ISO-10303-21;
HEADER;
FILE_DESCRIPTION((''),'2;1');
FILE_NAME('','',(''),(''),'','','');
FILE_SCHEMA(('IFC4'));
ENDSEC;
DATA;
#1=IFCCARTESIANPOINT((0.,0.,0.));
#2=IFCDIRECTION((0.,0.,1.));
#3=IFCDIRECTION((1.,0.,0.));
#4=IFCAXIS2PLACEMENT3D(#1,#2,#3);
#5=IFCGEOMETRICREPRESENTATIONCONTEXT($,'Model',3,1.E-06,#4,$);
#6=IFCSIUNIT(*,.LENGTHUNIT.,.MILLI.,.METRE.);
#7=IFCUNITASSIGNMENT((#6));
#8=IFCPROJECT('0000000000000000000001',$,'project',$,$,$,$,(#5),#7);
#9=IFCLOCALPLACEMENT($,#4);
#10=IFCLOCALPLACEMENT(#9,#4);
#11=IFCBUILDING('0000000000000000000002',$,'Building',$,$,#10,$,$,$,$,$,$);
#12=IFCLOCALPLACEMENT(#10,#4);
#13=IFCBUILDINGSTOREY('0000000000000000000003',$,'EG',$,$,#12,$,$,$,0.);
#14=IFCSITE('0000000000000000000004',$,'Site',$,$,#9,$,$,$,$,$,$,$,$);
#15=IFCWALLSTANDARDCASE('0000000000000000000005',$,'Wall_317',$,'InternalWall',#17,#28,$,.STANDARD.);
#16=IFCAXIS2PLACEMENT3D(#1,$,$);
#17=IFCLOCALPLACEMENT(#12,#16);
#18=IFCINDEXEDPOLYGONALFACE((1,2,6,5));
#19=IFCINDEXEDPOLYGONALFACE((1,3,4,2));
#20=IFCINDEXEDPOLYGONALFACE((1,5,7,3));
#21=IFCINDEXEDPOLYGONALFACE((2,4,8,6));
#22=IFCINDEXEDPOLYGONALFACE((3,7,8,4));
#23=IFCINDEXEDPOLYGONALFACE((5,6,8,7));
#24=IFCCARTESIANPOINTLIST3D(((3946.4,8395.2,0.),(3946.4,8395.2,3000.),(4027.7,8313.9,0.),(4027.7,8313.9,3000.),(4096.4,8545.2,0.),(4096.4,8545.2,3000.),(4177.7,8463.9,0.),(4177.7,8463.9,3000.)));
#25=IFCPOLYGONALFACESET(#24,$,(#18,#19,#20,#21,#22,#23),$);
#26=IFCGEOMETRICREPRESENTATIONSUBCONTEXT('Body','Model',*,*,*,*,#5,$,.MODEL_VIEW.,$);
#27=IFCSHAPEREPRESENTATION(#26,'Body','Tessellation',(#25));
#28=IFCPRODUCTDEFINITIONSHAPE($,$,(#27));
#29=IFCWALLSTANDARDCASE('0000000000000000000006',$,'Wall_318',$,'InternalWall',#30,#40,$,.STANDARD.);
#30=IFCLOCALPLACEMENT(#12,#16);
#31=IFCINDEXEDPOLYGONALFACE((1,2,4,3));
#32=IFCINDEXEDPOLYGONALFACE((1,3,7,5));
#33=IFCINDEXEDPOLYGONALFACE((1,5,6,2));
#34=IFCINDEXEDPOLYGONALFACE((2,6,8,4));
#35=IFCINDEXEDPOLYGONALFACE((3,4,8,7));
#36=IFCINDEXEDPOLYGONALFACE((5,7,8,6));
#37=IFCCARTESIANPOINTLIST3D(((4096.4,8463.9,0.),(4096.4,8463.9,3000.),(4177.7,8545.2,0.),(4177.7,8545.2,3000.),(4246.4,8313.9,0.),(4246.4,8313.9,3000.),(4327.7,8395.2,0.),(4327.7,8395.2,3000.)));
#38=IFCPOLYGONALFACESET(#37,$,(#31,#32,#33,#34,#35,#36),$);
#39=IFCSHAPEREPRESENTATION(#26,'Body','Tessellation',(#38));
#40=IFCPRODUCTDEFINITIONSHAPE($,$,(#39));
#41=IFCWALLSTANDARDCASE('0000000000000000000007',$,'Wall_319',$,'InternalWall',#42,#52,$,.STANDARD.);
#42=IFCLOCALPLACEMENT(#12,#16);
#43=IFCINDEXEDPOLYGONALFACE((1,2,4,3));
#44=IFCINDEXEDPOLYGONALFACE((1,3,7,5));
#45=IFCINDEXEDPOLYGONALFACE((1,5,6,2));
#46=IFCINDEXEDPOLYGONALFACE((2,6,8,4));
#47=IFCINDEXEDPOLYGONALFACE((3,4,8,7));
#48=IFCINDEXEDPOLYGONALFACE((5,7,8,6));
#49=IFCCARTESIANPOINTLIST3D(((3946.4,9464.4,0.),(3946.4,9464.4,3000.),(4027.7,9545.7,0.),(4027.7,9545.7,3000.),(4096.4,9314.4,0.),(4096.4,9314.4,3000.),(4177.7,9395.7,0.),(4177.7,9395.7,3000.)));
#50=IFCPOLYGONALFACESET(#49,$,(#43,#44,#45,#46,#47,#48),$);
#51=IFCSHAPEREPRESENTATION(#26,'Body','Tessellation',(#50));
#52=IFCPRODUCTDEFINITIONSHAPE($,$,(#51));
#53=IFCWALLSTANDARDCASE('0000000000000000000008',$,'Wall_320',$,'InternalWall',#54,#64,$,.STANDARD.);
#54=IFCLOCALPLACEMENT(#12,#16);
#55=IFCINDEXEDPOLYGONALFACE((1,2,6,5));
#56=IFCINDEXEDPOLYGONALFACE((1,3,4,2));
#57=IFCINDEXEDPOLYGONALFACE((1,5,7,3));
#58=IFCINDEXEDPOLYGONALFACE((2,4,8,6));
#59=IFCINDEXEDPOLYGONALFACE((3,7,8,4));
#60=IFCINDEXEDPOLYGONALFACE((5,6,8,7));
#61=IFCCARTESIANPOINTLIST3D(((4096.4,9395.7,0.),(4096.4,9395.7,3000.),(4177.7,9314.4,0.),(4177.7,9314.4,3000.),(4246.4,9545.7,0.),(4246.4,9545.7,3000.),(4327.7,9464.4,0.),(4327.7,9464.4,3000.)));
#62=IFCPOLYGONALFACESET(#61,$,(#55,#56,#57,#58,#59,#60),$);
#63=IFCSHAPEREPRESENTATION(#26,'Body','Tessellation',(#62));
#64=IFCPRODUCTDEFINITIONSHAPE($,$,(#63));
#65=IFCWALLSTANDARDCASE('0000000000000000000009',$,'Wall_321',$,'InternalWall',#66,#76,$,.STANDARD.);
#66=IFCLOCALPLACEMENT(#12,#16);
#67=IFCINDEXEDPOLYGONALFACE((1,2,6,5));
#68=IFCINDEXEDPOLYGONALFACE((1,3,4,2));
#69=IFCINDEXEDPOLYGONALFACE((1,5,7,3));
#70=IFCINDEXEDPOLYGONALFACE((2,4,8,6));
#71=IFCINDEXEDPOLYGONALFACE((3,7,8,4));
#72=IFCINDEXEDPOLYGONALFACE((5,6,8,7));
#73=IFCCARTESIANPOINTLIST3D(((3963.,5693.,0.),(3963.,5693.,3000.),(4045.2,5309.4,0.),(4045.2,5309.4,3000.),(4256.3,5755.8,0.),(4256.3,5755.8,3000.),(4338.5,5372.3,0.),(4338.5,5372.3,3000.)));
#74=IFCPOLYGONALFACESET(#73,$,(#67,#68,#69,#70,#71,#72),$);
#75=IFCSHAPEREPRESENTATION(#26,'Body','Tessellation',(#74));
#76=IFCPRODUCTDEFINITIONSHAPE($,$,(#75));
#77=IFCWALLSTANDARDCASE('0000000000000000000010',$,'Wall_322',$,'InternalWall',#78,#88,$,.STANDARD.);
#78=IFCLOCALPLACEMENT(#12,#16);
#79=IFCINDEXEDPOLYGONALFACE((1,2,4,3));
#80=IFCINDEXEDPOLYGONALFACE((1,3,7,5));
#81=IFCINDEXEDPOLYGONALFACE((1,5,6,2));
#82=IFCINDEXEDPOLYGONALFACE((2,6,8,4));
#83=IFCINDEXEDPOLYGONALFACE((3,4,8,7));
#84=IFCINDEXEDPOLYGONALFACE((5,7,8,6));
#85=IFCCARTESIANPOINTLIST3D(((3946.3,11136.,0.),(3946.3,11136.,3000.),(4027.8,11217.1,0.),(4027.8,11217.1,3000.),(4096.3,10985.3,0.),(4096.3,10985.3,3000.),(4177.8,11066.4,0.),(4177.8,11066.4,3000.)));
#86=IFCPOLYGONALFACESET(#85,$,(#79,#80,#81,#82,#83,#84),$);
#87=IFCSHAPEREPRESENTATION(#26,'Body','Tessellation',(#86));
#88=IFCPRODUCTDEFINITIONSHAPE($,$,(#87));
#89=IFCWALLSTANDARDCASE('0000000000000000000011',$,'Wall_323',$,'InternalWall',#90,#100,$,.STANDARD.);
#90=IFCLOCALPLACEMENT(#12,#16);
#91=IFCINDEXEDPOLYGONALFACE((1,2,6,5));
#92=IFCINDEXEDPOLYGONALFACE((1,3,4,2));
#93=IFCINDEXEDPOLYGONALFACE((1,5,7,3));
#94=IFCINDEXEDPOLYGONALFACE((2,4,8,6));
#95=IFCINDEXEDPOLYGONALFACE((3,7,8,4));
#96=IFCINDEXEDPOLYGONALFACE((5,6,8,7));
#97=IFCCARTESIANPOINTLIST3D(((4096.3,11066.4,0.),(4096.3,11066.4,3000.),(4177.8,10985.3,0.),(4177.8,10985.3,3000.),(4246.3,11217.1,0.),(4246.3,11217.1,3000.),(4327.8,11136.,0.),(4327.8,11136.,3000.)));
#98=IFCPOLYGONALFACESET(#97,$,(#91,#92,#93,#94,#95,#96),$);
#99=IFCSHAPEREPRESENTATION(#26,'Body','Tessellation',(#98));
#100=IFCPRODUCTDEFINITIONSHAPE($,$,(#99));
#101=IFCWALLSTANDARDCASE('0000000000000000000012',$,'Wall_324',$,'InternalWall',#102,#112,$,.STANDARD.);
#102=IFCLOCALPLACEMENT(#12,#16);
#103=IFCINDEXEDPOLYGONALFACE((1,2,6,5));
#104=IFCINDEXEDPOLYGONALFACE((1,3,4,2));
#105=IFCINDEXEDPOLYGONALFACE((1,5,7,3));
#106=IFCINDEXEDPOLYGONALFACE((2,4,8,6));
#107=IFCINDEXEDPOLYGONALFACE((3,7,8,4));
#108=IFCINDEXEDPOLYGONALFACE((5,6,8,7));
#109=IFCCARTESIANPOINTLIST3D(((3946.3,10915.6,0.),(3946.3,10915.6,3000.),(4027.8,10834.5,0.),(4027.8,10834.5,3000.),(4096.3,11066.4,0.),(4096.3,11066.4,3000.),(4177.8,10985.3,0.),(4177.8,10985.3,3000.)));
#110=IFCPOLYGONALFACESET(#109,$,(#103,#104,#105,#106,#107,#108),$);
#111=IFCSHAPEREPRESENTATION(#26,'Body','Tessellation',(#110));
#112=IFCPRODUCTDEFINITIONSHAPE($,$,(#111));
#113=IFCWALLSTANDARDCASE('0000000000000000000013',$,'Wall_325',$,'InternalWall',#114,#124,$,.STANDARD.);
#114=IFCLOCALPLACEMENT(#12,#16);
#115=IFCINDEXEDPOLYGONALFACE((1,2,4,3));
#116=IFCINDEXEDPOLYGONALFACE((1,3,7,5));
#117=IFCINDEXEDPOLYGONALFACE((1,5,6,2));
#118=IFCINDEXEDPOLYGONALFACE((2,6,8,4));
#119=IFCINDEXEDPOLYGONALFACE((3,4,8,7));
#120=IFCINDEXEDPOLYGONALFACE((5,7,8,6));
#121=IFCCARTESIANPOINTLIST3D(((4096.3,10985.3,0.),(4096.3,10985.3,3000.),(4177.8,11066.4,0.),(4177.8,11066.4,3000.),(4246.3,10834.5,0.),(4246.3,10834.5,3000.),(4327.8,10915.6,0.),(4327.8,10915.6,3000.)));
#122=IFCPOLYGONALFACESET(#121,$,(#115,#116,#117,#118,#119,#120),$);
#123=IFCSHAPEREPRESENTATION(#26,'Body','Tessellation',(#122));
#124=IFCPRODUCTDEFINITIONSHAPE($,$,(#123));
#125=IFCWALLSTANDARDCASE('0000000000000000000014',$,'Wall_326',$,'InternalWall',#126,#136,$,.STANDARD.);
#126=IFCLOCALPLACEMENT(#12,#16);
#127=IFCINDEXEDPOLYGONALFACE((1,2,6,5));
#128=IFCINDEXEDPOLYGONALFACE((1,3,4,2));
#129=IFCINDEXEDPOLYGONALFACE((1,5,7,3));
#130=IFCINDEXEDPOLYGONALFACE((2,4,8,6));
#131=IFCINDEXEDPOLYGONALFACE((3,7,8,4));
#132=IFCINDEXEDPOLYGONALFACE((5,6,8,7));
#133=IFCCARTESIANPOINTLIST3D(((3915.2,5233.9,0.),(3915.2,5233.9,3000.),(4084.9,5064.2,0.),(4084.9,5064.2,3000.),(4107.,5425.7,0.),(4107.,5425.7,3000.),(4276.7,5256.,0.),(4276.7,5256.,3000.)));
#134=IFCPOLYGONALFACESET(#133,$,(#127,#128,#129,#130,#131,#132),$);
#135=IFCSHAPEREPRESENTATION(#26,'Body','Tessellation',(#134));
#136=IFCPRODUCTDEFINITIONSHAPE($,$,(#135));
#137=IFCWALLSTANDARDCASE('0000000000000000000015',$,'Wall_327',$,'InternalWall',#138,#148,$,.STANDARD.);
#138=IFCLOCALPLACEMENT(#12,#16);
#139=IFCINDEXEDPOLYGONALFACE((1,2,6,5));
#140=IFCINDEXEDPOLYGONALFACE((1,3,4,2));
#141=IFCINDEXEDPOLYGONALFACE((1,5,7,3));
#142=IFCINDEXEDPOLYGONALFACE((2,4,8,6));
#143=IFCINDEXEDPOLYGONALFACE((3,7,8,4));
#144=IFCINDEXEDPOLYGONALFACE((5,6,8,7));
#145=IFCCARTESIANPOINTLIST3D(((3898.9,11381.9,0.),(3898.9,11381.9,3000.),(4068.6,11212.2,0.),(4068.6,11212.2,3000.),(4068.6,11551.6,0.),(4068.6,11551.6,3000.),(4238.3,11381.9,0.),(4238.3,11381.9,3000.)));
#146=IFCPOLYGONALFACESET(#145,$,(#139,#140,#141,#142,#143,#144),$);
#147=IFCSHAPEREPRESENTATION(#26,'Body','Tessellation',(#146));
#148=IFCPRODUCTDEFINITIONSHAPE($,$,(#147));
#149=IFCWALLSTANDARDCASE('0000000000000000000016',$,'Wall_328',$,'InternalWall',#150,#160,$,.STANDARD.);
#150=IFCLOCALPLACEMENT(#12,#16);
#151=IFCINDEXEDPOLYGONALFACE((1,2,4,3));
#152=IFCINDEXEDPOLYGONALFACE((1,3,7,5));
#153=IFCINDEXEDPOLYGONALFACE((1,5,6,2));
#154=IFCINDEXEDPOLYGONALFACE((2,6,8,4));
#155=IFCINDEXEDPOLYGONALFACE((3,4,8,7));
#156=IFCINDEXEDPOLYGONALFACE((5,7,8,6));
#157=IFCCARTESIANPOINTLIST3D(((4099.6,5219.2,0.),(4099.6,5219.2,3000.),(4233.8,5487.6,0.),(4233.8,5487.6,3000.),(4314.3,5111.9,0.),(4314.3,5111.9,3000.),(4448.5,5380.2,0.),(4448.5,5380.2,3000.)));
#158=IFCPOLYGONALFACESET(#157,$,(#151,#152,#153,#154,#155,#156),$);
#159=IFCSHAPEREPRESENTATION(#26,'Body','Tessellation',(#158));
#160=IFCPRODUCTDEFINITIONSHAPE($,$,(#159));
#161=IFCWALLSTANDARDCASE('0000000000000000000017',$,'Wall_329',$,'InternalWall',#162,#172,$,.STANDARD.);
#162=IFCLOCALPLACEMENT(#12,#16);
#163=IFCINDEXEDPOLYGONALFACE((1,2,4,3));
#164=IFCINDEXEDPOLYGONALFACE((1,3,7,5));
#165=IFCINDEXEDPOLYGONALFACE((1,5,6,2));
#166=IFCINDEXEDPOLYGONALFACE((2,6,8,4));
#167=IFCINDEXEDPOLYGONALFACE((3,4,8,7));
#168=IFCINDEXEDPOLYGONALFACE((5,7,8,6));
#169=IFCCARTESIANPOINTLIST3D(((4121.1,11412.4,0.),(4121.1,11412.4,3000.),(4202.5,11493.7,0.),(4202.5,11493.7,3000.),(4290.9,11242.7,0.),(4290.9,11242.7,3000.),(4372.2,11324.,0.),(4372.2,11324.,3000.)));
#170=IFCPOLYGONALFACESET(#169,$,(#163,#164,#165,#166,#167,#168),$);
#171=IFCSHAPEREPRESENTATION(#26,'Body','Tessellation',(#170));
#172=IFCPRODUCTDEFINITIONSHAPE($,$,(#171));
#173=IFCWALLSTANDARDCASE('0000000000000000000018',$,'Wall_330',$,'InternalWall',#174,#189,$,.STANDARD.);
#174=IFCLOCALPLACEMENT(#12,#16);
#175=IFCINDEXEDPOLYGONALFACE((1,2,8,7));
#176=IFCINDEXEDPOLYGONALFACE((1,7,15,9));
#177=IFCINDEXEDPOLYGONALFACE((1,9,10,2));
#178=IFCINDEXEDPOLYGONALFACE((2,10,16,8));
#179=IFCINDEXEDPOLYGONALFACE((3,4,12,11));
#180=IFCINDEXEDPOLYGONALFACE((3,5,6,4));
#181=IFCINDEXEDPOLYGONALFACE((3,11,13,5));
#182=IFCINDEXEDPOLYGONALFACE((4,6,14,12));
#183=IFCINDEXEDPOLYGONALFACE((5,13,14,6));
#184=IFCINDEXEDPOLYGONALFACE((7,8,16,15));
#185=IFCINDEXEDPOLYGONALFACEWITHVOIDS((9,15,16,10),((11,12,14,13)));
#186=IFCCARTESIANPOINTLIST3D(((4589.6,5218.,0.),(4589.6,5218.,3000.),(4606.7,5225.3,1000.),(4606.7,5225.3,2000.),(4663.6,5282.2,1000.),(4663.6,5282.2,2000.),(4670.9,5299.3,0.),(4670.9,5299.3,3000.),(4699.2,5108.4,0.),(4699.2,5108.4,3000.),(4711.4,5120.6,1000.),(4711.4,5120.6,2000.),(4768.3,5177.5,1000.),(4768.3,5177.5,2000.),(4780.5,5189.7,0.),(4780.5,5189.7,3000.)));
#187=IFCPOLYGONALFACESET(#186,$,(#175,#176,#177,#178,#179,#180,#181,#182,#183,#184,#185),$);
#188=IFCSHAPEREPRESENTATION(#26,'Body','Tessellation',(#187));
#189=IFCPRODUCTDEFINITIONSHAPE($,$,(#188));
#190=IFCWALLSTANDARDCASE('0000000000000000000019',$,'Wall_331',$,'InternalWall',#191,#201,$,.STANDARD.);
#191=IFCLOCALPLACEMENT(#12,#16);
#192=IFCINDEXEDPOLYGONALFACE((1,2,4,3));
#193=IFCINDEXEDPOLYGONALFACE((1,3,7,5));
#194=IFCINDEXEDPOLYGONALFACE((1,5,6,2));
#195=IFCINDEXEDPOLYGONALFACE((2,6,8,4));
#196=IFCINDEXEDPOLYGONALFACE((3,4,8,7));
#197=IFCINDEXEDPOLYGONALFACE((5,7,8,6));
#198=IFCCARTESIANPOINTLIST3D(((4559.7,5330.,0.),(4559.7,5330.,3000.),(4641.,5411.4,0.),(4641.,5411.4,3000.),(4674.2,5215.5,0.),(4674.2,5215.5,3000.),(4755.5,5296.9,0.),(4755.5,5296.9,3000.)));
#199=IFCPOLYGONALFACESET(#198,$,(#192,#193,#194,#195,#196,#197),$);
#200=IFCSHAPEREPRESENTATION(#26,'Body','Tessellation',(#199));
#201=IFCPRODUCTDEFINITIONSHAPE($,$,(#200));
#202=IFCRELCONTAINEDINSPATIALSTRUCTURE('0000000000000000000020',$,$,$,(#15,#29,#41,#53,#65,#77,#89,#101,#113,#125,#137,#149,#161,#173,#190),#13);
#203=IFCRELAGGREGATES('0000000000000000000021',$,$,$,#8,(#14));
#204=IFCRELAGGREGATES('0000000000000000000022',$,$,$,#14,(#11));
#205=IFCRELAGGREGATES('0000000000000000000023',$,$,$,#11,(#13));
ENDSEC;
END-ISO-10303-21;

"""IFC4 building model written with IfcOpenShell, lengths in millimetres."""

from ifc_helpers import new_model, si_unit, frame, origin_with_axes, place, context, subcontext, project, spatial, rectangle, extrude, element, save


model = new_model("IFC4")

# Units and contexts
model_context = context("Model", 3, precision=1e-06, world=origin_with_axes())
body_context = subcontext(model_context, "Body", "Model", "MODEL_VIEW")
ifc_project = project(units=[si_unit("LENGTHUNIT", "METRE", prefix="MILLI")], contexts=[model_context])

# Site, building, storey
site_placement = place(None, origin_with_axes())
site = spatial("IfcSite", under=ifc_project, at=site_placement, Name="Site")
building_placement = place(site_placement, origin_with_axes())
building = spatial("IfcBuilding", under=site, at=building_placement, Name="Building")
storey_placement = place(building_placement, origin_with_axes())
storey = spatial("IfcBuildingStorey", under=building, at=storey_placement, Name="EG", Elevation=0.0)

# Walls
wall_1_placement = place(storey_placement, origin_with_axes())
element("IfcWallStandardCase", 1, at=wall_1_placement, inside=storey, Name="Wall_317", ObjectType="InternalWall", PredefinedType="STANDARD", context=body_context, shape_type="SweptSolid", body=[
    extrude(rectangle(XDim=212.1, YDim=115.0), frame((4062.1, 8429.5, 0.0), z_axis=(0.0, 0.0, 1.0), x_axis=(-0.707107, -0.707107, 0.0)), (0.0, 0.0, 1.0), 3000.0),
])
wall_2_placement = place(storey_placement, origin_with_axes())
element("IfcWallStandardCase", 2, at=wall_2_placement, inside=storey, Name="Wall_318", ObjectType="InternalWall", PredefinedType="STANDARD", context=body_context, shape_type="SweptSolid", body=[
    extrude(rectangle(XDim=212.1, YDim=115.0), frame((4212.1, 8429.5, 0.0), z_axis=(0.0, 0.0, 1.0), x_axis=(0.707107, -0.707107, 0.0)), (0.0, 0.0, 1.0), 3000.0),
])
wall_3_placement = place(storey_placement, origin_with_axes())
element("IfcWallStandardCase", 3, at=wall_3_placement, inside=storey, Name="Wall_319", ObjectType="InternalWall", PredefinedType="STANDARD", context=body_context, shape_type="SweptSolid", body=[
    extrude(rectangle(XDim=212.1, YDim=115.0), frame((4062.1, 9430.0, 0.0), z_axis=(0.0, 0.0, 1.0), x_axis=(-0.707107, 0.707107, 0.0)), (0.0, 0.0, 1.0), 3000.0),
])
wall_4_placement = place(storey_placement, origin_with_axes())
element("IfcWallStandardCase", 4, at=wall_4_placement, inside=storey, Name="Wall_320", ObjectType="InternalWall", PredefinedType="STANDARD", context=body_context, shape_type="SweptSolid", body=[
    extrude(rectangle(XDim=212.1, YDim=115.0), frame((4212.1, 9430.0, 0.0), z_axis=(0.0, 0.0, 1.0), x_axis=(0.707107, 0.707107, 0.0)), (0.0, 0.0, 1.0), 3000.0),
])
wall_5_placement = place(storey_placement, origin_with_axes())
element("IfcWallStandardCase", 5, at=wall_5_placement, inside=storey, Name="Wall_321", ObjectType="InternalWall", PredefinedType="STANDARD", context=body_context, shape_type="SweptSolid", body=[
    extrude(rectangle(XDim=392.3, YDim=300.0), frame((4150.8, 5532.6, 0.0), z_axis=(0.0, 0.0, 1.0), x_axis=(-0.209529, 0.977802, 0.0)), (0.0, 0.0, 1.0), 3000.0),
])
wall_6_placement = place(storey_placement, origin_with_axes())
element("IfcWallStandardCase", 6, at=wall_6_placement, inside=storey, Name="Wall_322", ObjectType="InternalWall", PredefinedType="STANDARD", context=body_context, shape_type="SweptSolid", body=[
    extrude(rectangle(XDim=212.7, YDim=115.0), frame((4062.1, 11101.2, 0.0), z_axis=(0.0, 0.0, 1.0), x_axis=(0.705341, -0.708868, 0.0)), (0.0, 0.0, 1.0), 3000.0),
])
wall_7_placement = place(storey_placement, origin_with_axes())
element("IfcWallStandardCase", 7, at=wall_7_placement, inside=storey, Name="Wall_323", ObjectType="InternalWall", PredefinedType="STANDARD", context=body_context, shape_type="SweptSolid", body=[
    extrude(rectangle(XDim=212.7, YDim=115.0), frame((4212.1, 11101.2, 0.0), z_axis=(0.0, 0.0, 1.0), x_axis=(0.705341, 0.708868, 0.0)), (0.0, 0.0, 1.0), 3000.0),
])
wall_8_placement = place(storey_placement, origin_with_axes())
element("IfcWallStandardCase", 8, at=wall_8_placement, inside=storey, Name="Wall_324", ObjectType="InternalWall", PredefinedType="STANDARD", context=body_context, shape_type="SweptSolid", body=[
    extrude(rectangle(XDim=212.7, YDim=115.0), frame((4062.1, 10950.5, 0.0), z_axis=(0.0, 0.0, 1.0), x_axis=(-0.705341, -0.708868, 0.0)), (0.0, 0.0, 1.0), 3000.0),
])
wall_9_placement = place(storey_placement, origin_with_axes())
element("IfcWallStandardCase", 9, at=wall_9_placement, inside=storey, Name="Wall_325", ObjectType="InternalWall", PredefinedType="STANDARD", context=body_context, shape_type="SweptSolid", body=[
    extrude(rectangle(XDim=212.7, YDim=115.0), frame((4212.1, 10950.5, 0.0), z_axis=(0.0, 0.0, 1.0), x_axis=(0.705341, -0.708868, 0.0)), (0.0, 0.0, 1.0), 3000.0),
])
wall_10_placement = place(storey_placement, origin_with_axes())
element("IfcWallStandardCase", 10, at=wall_10_placement, inside=storey, Name="Wall_326", ObjectType="InternalWall", PredefinedType="STANDARD", context=body_context, shape_type="SweptSolid", body=[
    extrude(rectangle(XDim=271.2, YDim=240.0), frame((4096.0, 5244.9, 0.0), z_axis=(0.0, 0.0, 1.0), x_axis=(-0.707107, -0.707107, 0.0)), (0.0, 0.0, 1.0), 3000.0),
])
wall_11_placement = place(storey_placement, origin_with_axes())
element("IfcWallStandardCase", 11, at=wall_11_placement, inside=storey, Name="Wall_327", ObjectType="InternalWall", PredefinedType="STANDARD", context=body_context, shape_type="SweptSolid", body=[
    extrude(rectangle(XDim=240.0, YDim=240.0), frame((4068.6, 11381.9, 0.0), z_axis=(0.0, 0.0, 1.0), x_axis=(0.707107, 0.707107, 0.0)), (0.0, 0.0, 1.0), 3000.0),
])
wall_12_placement = place(storey_placement, origin_with_axes())
element("IfcWallStandardCase", 12, at=wall_12_placement, inside=storey, Name="Wall_328", ObjectType="InternalWall", PredefinedType="STANDARD", context=body_context, shape_type="SweptSolid", body=[
    extrude(rectangle(XDim=300.0, YDim=240.0), frame((4274.1, 5299.7, 0.0), z_axis=(0.0, 0.0, 1.0), x_axis=(0.447214, 0.894427, 0.0)), (0.0, 0.0, 1.0), 3000.0),
])
wall_13_placement = place(storey_placement, origin_with_axes())
element("IfcWallStandardCase", 13, at=wall_13_placement, inside=storey, Name="Wall_329", ObjectType="InternalWall", PredefinedType="STANDARD", context=body_context, shape_type="SweptSolid", body=[
    extrude(rectangle(XDim=240.0, YDim=115.0), frame((4246.7, 11368.2, 0.0), z_axis=(0.0, 0.0, 1.0), x_axis=(0.707107, -0.707107, 0.0)), (0.0, 0.0, 1.0), 3000.0),
])

# Wall, opening
wall_14_placement = place(storey_placement, origin_with_axes())
wall_14 = element("IfcWallStandardCase", 14, at=wall_14_placement, inside=storey, Name="Wall_330", ObjectType="InternalWall", PredefinedType="STANDARD", context=body_context, shape_type="SweptSolid", body=[
    extrude(rectangle(XDim=155.0, YDim=115.0), frame((4685.0, 5203.9, 0.0), z_axis=(0.0, 0.0, 1.0), x_axis=(-0.707107, 0.707107, 0.0)), (0.0, 0.0, 1.0), 3000.0),
])
opening_placement = place(wall_14_placement, origin_with_axes())
element("IfcOpeningElement", 15, at=opening_placement, inside=storey, cuts=wall_14, context=body_context, shape_type="SweptSolid", body=[
    extrude(rectangle(XDim=2370.5, YDim=80.5), frame((5473.2, 4415.6, 1000.0), z_axis=(0.0, 0.0, 1.0), x_axis=(-0.707107, 0.707107, 0.0)), (0.0, 0.0, 1.0), 1000.0),
])

# Wall
wall_15_placement = place(storey_placement, origin_with_axes())
element("IfcWallStandardCase", 16, at=wall_15_placement, inside=storey, Name="Wall_331", ObjectType="InternalWall", PredefinedType="STANDARD", context=body_context, shape_type="SweptSolid", body=[
    extrude(rectangle(XDim=161.9, YDim=115.0), frame((4657.6, 5313.4, 0.0), z_axis=(0.0, 0.0, 1.0), x_axis=(0.707107, -0.707107, 0.0)), (0.0, 0.0, 1.0), 3000.0),
])

save(model, "model.ifc")
